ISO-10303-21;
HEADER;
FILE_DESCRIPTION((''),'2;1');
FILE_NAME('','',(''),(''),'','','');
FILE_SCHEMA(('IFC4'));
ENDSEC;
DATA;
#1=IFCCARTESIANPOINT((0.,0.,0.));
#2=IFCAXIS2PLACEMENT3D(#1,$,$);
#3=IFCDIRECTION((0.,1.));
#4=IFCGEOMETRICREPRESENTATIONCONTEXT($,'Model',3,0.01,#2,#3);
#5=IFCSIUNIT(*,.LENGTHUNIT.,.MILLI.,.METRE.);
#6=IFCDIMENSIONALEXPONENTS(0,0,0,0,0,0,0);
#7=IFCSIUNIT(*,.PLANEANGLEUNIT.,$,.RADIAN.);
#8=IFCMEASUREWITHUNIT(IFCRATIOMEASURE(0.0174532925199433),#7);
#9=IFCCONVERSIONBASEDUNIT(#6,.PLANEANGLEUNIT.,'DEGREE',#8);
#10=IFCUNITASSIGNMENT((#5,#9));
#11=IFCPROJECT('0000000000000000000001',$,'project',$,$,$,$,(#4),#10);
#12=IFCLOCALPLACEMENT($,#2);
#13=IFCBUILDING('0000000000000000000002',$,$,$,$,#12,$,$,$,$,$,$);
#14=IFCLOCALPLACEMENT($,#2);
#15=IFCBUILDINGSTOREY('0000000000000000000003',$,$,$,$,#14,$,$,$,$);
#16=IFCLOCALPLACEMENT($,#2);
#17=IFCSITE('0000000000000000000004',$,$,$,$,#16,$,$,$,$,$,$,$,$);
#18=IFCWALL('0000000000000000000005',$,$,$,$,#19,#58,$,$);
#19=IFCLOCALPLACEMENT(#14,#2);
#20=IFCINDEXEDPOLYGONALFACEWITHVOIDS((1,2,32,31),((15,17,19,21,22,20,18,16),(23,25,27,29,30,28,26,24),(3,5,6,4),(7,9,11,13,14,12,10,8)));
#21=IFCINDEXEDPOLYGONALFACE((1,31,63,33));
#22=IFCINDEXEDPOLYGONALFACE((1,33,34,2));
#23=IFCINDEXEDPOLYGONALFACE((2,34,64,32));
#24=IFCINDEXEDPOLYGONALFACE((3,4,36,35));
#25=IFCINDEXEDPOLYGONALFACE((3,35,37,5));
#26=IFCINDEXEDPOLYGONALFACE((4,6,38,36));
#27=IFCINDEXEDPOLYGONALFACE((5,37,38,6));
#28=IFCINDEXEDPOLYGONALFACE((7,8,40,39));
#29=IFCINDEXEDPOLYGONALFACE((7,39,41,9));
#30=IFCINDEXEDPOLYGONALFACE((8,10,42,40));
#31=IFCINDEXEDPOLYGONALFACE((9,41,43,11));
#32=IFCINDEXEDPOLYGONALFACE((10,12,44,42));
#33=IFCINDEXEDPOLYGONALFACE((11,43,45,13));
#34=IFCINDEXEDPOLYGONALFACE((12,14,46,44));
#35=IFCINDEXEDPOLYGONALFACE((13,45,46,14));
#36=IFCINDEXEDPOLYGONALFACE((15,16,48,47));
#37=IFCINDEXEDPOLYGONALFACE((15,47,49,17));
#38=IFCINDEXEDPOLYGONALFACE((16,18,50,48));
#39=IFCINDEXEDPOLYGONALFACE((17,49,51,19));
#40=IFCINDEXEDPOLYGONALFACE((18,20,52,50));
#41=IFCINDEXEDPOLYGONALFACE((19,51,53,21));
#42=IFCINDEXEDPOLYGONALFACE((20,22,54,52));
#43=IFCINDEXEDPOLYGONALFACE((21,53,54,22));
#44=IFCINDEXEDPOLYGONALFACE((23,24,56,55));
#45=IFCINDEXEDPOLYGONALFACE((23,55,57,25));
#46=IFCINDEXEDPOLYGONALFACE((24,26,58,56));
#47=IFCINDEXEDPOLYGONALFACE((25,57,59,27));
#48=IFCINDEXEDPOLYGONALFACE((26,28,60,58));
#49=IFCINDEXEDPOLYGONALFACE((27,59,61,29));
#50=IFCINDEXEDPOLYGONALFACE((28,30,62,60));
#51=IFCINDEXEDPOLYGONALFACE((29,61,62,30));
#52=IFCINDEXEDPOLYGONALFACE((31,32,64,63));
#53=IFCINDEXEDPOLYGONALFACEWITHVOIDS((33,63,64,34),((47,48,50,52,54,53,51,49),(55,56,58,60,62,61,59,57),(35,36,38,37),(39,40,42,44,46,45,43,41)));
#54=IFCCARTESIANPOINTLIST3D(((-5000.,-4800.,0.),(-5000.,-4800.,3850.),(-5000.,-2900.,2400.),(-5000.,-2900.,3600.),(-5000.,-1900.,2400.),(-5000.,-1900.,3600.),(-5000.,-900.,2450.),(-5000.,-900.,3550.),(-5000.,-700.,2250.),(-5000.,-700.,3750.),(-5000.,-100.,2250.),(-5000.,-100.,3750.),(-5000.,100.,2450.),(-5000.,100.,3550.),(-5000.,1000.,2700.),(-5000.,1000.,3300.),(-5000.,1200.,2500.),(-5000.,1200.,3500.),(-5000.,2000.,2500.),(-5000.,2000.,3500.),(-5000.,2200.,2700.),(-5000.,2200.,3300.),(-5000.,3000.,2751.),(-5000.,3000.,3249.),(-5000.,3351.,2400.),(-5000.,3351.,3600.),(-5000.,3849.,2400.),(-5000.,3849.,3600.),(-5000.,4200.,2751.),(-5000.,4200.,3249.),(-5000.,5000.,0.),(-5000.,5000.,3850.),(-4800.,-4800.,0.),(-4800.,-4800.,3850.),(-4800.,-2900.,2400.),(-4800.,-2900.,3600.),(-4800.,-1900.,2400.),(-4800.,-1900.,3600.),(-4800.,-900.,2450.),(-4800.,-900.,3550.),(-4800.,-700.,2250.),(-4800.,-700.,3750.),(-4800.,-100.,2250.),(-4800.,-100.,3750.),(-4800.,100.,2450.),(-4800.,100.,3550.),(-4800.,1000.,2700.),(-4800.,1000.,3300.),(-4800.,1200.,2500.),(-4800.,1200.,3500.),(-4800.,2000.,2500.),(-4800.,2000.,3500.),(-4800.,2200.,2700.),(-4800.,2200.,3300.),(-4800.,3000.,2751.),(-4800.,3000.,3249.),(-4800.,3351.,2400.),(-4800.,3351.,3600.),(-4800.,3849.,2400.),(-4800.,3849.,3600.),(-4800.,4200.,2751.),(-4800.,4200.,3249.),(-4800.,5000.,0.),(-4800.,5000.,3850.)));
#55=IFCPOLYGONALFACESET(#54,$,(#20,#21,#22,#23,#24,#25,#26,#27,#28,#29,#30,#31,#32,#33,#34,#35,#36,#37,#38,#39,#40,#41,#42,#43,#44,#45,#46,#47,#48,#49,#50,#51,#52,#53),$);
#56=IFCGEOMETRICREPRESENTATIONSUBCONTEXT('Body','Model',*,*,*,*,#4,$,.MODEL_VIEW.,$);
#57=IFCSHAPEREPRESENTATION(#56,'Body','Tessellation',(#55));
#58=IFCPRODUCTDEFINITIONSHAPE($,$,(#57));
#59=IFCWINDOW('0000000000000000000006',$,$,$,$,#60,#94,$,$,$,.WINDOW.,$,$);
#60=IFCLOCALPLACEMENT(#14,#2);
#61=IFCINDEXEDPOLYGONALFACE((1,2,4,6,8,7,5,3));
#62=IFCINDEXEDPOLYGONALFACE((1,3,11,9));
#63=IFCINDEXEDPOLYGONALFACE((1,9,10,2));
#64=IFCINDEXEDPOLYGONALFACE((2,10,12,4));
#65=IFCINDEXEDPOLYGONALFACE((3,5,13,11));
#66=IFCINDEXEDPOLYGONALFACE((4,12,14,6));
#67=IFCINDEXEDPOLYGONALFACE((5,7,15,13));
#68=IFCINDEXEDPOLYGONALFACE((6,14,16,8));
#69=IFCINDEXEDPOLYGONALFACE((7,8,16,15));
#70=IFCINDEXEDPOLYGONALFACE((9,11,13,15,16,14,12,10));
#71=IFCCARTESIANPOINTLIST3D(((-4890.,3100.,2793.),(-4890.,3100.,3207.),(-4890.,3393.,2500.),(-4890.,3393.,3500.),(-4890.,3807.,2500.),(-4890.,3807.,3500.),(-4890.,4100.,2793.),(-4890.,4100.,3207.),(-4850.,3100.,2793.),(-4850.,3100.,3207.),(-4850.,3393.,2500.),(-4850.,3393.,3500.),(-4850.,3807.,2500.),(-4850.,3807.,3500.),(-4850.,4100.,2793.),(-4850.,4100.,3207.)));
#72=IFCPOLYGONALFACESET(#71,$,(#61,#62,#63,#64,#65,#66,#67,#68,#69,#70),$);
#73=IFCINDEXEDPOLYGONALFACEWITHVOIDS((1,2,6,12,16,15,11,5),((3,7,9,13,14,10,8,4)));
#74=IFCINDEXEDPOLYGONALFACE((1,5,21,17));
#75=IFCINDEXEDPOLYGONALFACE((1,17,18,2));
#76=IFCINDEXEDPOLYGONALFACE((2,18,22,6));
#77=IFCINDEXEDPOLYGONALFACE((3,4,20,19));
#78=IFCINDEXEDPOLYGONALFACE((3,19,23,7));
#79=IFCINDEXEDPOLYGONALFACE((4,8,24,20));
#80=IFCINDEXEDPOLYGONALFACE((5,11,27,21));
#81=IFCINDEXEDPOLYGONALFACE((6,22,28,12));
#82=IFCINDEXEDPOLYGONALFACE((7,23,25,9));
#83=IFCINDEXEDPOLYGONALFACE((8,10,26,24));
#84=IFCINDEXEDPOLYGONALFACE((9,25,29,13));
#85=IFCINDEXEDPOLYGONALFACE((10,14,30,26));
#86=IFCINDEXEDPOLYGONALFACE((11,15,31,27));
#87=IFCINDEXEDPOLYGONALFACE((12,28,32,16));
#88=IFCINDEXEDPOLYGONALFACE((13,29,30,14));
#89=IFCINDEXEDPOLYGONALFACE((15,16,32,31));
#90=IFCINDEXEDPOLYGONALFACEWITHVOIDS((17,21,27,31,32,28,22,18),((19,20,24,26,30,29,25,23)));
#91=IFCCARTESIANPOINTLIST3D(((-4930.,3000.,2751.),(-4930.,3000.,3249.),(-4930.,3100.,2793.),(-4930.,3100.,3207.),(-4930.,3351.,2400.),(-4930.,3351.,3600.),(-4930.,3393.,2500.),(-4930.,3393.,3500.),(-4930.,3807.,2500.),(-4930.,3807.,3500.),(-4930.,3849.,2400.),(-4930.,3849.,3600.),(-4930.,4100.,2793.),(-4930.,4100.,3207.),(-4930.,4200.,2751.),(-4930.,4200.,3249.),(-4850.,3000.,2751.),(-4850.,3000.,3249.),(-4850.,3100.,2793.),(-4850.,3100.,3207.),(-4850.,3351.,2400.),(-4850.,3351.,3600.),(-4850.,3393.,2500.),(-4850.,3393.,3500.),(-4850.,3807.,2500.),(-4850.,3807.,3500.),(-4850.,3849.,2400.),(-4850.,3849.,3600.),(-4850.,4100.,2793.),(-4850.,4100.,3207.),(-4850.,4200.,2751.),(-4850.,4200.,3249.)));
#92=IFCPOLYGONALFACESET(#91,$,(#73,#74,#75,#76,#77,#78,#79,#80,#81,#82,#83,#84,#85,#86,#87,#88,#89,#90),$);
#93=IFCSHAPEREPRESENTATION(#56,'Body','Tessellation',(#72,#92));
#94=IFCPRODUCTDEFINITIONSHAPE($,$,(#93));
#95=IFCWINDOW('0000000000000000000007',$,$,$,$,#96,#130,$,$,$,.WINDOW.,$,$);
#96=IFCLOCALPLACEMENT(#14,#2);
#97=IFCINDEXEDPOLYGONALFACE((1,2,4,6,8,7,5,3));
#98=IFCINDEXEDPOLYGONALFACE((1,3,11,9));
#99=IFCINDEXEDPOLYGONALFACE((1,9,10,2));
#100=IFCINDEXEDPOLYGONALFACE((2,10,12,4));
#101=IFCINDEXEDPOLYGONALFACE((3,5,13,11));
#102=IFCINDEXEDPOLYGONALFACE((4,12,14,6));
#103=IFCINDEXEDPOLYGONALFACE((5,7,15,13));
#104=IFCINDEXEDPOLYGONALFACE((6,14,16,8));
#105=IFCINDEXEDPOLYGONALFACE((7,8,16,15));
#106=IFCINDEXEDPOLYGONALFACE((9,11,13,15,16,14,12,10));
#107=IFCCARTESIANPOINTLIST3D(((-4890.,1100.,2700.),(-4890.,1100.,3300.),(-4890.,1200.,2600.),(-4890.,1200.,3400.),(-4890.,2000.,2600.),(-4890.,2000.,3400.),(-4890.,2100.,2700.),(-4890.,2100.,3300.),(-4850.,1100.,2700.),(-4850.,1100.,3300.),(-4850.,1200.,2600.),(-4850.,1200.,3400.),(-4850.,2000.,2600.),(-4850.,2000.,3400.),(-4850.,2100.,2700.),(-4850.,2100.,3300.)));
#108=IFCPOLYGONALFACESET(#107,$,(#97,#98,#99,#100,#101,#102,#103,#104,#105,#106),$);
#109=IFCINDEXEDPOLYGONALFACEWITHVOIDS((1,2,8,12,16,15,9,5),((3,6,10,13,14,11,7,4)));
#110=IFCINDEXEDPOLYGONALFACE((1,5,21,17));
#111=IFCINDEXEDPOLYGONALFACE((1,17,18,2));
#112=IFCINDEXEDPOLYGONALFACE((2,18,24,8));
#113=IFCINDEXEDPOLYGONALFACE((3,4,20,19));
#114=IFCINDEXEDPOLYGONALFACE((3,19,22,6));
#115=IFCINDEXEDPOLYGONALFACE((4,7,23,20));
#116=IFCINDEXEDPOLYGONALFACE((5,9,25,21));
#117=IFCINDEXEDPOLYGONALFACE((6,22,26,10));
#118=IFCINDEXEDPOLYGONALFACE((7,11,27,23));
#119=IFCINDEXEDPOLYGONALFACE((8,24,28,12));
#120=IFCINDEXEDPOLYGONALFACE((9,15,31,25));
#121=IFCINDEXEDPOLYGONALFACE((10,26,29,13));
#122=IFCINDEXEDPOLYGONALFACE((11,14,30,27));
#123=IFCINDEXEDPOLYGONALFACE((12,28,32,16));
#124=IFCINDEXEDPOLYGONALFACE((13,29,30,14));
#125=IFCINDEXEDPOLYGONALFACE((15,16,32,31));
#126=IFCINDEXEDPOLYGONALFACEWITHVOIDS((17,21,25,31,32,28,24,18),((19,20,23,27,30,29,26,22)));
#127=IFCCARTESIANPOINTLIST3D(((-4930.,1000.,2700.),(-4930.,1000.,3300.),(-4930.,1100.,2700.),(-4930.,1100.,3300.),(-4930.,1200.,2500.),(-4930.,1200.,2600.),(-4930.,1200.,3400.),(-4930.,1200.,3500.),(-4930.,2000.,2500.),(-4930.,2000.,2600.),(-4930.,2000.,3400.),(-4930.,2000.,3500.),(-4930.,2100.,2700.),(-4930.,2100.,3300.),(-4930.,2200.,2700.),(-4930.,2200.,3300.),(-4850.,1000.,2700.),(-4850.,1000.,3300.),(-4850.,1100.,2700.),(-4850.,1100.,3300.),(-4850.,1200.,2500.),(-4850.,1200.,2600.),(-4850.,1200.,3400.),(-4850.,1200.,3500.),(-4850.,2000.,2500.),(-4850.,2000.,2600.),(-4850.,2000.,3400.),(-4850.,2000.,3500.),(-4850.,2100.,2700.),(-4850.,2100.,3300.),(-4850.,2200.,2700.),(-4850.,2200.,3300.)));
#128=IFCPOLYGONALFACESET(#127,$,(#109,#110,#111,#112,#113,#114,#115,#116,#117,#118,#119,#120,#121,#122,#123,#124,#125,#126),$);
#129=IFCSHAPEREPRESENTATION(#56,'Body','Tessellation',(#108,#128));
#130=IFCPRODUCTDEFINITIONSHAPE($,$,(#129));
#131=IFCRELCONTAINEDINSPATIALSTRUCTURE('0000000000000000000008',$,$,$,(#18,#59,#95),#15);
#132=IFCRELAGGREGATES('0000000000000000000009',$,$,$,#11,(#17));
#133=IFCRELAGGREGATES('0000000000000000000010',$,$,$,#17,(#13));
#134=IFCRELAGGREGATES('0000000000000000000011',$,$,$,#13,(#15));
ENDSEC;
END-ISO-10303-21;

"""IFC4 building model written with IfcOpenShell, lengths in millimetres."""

from ifc_helpers import new_model, entity, si_unit, converted_unit, direction, frame, origin, origin_2d, place, context, subcontext, project, spatial, polyline, rectangle, outline, extrude, element, save


model = new_model("IFC4")

# Units and contexts
model_context = context("Model", 3, precision=0.01, world=origin(), true_north=direction((0.0, 1.0)))
body_context = subcontext(model_context, "Body", "Model", "MODEL_VIEW")
ifc_project = project(units=[si_unit("LENGTHUNIT", "METRE", prefix="MILLI"), converted_unit("PLANEANGLEUNIT", "DEGREE", entity("IfcRatioMeasure", 0.0174532925199433), si_unit("PLANEANGLEUNIT", "RADIAN"), dimensions=[0, 0, 0, 0, 0, 0, 0])], contexts=[model_context])

# Site, building, storey
site_placement = place(None, origin())
site = spatial("IfcSite", under=ifc_project, at=site_placement)
building_placement = place(None, origin())
building = spatial("IfcBuilding", under=site, at=building_placement)
storey_placement = place(None, origin())
storey = spatial("IfcBuildingStorey", under=building, at=storey_placement)

# Shared definitions
cartesian_point_1 = entity("IfcCartesianPoint", [-500.0, -207.0])
shared_polyline_1 = entity("IfcPolyline", [cartesian_point_1, entity("IfcCartesianPoint", [-500.0, 207.0]), entity("IfcCartesianPoint", [-207.0, 500.0]), entity("IfcCartesianPoint", [207.0, 500.0]), entity("IfcCartesianPoint", [500.0, 207.0]), entity("IfcCartesianPoint", [500.0, -207.0]), entity("IfcCartesianPoint", [207.0, -500.0]), entity("IfcCartesianPoint", [-207.0, -500.0]), cartesian_point_1])
cartesian_point_2 = entity("IfcCartesianPoint", [-500.0, -300.0])
shared_polyline_2 = entity("IfcPolyline", [cartesian_point_2, entity("IfcCartesianPoint", [-500.0, 300.0]), entity("IfcCartesianPoint", [-400.0, 400.0]), entity("IfcCartesianPoint", [400.0, 400.0]), entity("IfcCartesianPoint", [500.0, 300.0]), entity("IfcCartesianPoint", [500.0, -300.0]), entity("IfcCartesianPoint", [400.0, -400.0]), entity("IfcCartesianPoint", [-400.0, -400.0]), cartesian_point_2])

# Wall, openings
wall_1_placement = place(storey_placement, frame((-4900.0, 100.0, 0.0), z_axis=(0.0, 0.0, 1.0), x_axis=(0.0, -1.0, 0.0)))
wall_1 = element("IfcWall", 1, at=wall_1_placement, inside=storey, context=body_context, shape_type="SweptSolid", body=[
    extrude(rectangle(XDim=9800.0, YDim=200.0, at=origin_2d()), origin(), (0.0, 0.0, 1.0), 3850.0),
])
window_1_placement = place(wall_1_placement, frame((-3500.0, 50.0, 3000.0)))
opening_1_placement = place(window_1_placement, frame((0.0, 50.0, 0.0)))
element("IfcOpeningElement", 2, at=opening_1_placement, cuts=wall_1, context=body_context, shape_type="SweptSolid", body=[
    extrude(outline(polyline([(-600.0, -249.0), (-600.0, 249.0), (-249.0, 600.0), (249.0, 600.0), (600.0, 249.0), (600.0, -249.0), (249.0, -600.0), (-249.0, -600.0), (-600.0, -249.0)])), frame((0.0, 0.0, 0.0), z_axis=(0.0, -1.0, 0.0), x_axis=(1.0, 0.0, 0.0)), (0.0, 0.0, 1.0), 200.0),
])
window_2_placement = place(wall_1_placement, frame((-1500.0, 50.0, 3000.0)))
opening_2_placement = place(window_2_placement, frame((0.0, 50.0, 0.0)))
element("IfcOpeningElement", 3, at=opening_2_placement, cuts=wall_1, context=body_context, shape_type="SweptSolid", body=[
    extrude(outline(polyline([(-600.0, -300.0), (-600.0, 300.0), (-400.0, 500.0), (400.0, 500.0), (600.0, 300.0), (600.0, -300.0), (400.0, -500.0), (-400.0, -500.0), (-600.0, -300.0)])), frame((0.0, 0.0, 0.0), z_axis=(0.0, -1.0, 0.0), x_axis=(1.0, 0.0, 0.0)), (0.0, 0.0, 1.0), 200.0),
])
window_3_placement = place(wall_1_placement, frame((500.0, 50.0, 3000.0)))
opening_3_placement = place(window_3_placement, frame((0.0, 50.0, 0.0)))
element("IfcOpeningElement", 4, at=opening_3_placement, cuts=wall_1, context=body_context, shape_type="SweptSolid", body=[
    extrude(outline(polyline([(-500.0, -550.0), (-500.0, 550.0), (-300.0, 750.0), (300.0, 750.0), (500.0, 550.0), (500.0, -550.0), (300.0, -750.0), (-300.0, -750.0), (-500.0, -550.0)])), frame((0.0, 0.0, 0.0), z_axis=(0.0, -1.0, 0.0), x_axis=(1.0, 0.0, 0.0)), (0.0, 0.0, 1.0), 200.0),
])
window_4_placement = place(wall_1_placement, frame((2500.0, 50.0, 3000.0)))
opening_4_placement = place(window_4_placement, frame((0.0, 50.0, 0.0)))
element("IfcOpeningElement", 5, at=opening_4_placement, cuts=wall_1, context=body_context, shape_type="SweptSolid", body=[
    extrude(outline(polyline([(-500.0, -600.0), (-500.0, 600.0), (-500.0, 600.0), (500.0, 600.0), (500.0, 600.0), (500.0, -600.0), (500.0, -600.0), (-500.0, -600.0), (-500.0, -600.0)])), frame((0.0, 0.0, 0.0), z_axis=(0.0, -1.0, 0.0), x_axis=(1.0, 0.0, 0.0)), (0.0, 0.0, 1.0), 200.0),
])

# Windows
cartesian_point_3 = entity("IfcCartesianPoint", [-600.0, -249.0])
element("IfcWindow", 6, at=window_1_placement, inside=storey, PredefinedType="WINDOW", context=body_context, shape_type="SweptSolid", body=[
    entity("IfcExtrudedAreaSolid", entity("IfcArbitraryClosedProfileDef", "AREA", None, shared_polyline_1), entity("IfcAxis2Placement3D", entity("IfcCartesianPoint", [0.0, 0.0, 0.0]), entity("IfcDirection", [0.0, -1.0, 0.0]), entity("IfcDirection", [1.0, 0.0, 0.0])), entity("IfcDirection", [0.0, 0.0, 1.0]), 40.0),
    entity("IfcExtrudedAreaSolid", entity("IfcArbitraryProfileDefWithVoids", "AREA", None, entity("IfcPolyline", [cartesian_point_3, entity("IfcCartesianPoint", [-600.0, 249.0]), entity("IfcCartesianPoint", [-249.0, 600.0]), entity("IfcCartesianPoint", [249.0, 600.0]), entity("IfcCartesianPoint", [600.0, 249.0]), entity("IfcCartesianPoint", [600.0, -249.0]), entity("IfcCartesianPoint", [249.0, -600.0]), entity("IfcCartesianPoint", [-249.0, -600.0]), cartesian_point_3]), [shared_polyline_1]), entity("IfcAxis2Placement3D", entity("IfcCartesianPoint", [0.0, 0.0, 0.0]), entity("IfcDirection", [0.0, -1.0, 0.0]), entity("IfcDirection", [1.0, 0.0, 0.0])), entity("IfcDirection", [0.0, 0.0, 1.0]), 80.0),
])
cartesian_point_4 = entity("IfcCartesianPoint", [-600.0, -300.0])
element("IfcWindow", 7, at=window_2_placement, inside=storey, PredefinedType="WINDOW", context=body_context, shape_type="SweptSolid", body=[
    entity("IfcExtrudedAreaSolid", entity("IfcArbitraryClosedProfileDef", "AREA", None, shared_polyline_2), entity("IfcAxis2Placement3D", entity("IfcCartesianPoint", [0.0, 0.0, 0.0]), entity("IfcDirection", [0.0, -1.0, 0.0]), entity("IfcDirection", [1.0, 0.0, 0.0])), entity("IfcDirection", [0.0, 0.0, 1.0]), 40.0),
    entity("IfcExtrudedAreaSolid", entity("IfcArbitraryProfileDefWithVoids", "AREA", None, entity("IfcPolyline", [cartesian_point_4, entity("IfcCartesianPoint", [-600.0, 300.0]), entity("IfcCartesianPoint", [-400.0, 500.0]), entity("IfcCartesianPoint", [400.0, 500.0]), entity("IfcCartesianPoint", [600.0, 300.0]), entity("IfcCartesianPoint", [600.0, -300.0]), entity("IfcCartesianPoint", [400.0, -500.0]), entity("IfcCartesianPoint", [-400.0, -500.0]), cartesian_point_4]), [shared_polyline_2]), entity("IfcAxis2Placement3D", entity("IfcCartesianPoint", [0.0, 0.0, 0.0]), entity("IfcDirection", [0.0, -1.0, 0.0]), entity("IfcDirection", [1.0, 0.0, 0.0])), entity("IfcDirection", [0.0, 0.0, 1.0]), 80.0),
])

save(model, "model.ifc")
